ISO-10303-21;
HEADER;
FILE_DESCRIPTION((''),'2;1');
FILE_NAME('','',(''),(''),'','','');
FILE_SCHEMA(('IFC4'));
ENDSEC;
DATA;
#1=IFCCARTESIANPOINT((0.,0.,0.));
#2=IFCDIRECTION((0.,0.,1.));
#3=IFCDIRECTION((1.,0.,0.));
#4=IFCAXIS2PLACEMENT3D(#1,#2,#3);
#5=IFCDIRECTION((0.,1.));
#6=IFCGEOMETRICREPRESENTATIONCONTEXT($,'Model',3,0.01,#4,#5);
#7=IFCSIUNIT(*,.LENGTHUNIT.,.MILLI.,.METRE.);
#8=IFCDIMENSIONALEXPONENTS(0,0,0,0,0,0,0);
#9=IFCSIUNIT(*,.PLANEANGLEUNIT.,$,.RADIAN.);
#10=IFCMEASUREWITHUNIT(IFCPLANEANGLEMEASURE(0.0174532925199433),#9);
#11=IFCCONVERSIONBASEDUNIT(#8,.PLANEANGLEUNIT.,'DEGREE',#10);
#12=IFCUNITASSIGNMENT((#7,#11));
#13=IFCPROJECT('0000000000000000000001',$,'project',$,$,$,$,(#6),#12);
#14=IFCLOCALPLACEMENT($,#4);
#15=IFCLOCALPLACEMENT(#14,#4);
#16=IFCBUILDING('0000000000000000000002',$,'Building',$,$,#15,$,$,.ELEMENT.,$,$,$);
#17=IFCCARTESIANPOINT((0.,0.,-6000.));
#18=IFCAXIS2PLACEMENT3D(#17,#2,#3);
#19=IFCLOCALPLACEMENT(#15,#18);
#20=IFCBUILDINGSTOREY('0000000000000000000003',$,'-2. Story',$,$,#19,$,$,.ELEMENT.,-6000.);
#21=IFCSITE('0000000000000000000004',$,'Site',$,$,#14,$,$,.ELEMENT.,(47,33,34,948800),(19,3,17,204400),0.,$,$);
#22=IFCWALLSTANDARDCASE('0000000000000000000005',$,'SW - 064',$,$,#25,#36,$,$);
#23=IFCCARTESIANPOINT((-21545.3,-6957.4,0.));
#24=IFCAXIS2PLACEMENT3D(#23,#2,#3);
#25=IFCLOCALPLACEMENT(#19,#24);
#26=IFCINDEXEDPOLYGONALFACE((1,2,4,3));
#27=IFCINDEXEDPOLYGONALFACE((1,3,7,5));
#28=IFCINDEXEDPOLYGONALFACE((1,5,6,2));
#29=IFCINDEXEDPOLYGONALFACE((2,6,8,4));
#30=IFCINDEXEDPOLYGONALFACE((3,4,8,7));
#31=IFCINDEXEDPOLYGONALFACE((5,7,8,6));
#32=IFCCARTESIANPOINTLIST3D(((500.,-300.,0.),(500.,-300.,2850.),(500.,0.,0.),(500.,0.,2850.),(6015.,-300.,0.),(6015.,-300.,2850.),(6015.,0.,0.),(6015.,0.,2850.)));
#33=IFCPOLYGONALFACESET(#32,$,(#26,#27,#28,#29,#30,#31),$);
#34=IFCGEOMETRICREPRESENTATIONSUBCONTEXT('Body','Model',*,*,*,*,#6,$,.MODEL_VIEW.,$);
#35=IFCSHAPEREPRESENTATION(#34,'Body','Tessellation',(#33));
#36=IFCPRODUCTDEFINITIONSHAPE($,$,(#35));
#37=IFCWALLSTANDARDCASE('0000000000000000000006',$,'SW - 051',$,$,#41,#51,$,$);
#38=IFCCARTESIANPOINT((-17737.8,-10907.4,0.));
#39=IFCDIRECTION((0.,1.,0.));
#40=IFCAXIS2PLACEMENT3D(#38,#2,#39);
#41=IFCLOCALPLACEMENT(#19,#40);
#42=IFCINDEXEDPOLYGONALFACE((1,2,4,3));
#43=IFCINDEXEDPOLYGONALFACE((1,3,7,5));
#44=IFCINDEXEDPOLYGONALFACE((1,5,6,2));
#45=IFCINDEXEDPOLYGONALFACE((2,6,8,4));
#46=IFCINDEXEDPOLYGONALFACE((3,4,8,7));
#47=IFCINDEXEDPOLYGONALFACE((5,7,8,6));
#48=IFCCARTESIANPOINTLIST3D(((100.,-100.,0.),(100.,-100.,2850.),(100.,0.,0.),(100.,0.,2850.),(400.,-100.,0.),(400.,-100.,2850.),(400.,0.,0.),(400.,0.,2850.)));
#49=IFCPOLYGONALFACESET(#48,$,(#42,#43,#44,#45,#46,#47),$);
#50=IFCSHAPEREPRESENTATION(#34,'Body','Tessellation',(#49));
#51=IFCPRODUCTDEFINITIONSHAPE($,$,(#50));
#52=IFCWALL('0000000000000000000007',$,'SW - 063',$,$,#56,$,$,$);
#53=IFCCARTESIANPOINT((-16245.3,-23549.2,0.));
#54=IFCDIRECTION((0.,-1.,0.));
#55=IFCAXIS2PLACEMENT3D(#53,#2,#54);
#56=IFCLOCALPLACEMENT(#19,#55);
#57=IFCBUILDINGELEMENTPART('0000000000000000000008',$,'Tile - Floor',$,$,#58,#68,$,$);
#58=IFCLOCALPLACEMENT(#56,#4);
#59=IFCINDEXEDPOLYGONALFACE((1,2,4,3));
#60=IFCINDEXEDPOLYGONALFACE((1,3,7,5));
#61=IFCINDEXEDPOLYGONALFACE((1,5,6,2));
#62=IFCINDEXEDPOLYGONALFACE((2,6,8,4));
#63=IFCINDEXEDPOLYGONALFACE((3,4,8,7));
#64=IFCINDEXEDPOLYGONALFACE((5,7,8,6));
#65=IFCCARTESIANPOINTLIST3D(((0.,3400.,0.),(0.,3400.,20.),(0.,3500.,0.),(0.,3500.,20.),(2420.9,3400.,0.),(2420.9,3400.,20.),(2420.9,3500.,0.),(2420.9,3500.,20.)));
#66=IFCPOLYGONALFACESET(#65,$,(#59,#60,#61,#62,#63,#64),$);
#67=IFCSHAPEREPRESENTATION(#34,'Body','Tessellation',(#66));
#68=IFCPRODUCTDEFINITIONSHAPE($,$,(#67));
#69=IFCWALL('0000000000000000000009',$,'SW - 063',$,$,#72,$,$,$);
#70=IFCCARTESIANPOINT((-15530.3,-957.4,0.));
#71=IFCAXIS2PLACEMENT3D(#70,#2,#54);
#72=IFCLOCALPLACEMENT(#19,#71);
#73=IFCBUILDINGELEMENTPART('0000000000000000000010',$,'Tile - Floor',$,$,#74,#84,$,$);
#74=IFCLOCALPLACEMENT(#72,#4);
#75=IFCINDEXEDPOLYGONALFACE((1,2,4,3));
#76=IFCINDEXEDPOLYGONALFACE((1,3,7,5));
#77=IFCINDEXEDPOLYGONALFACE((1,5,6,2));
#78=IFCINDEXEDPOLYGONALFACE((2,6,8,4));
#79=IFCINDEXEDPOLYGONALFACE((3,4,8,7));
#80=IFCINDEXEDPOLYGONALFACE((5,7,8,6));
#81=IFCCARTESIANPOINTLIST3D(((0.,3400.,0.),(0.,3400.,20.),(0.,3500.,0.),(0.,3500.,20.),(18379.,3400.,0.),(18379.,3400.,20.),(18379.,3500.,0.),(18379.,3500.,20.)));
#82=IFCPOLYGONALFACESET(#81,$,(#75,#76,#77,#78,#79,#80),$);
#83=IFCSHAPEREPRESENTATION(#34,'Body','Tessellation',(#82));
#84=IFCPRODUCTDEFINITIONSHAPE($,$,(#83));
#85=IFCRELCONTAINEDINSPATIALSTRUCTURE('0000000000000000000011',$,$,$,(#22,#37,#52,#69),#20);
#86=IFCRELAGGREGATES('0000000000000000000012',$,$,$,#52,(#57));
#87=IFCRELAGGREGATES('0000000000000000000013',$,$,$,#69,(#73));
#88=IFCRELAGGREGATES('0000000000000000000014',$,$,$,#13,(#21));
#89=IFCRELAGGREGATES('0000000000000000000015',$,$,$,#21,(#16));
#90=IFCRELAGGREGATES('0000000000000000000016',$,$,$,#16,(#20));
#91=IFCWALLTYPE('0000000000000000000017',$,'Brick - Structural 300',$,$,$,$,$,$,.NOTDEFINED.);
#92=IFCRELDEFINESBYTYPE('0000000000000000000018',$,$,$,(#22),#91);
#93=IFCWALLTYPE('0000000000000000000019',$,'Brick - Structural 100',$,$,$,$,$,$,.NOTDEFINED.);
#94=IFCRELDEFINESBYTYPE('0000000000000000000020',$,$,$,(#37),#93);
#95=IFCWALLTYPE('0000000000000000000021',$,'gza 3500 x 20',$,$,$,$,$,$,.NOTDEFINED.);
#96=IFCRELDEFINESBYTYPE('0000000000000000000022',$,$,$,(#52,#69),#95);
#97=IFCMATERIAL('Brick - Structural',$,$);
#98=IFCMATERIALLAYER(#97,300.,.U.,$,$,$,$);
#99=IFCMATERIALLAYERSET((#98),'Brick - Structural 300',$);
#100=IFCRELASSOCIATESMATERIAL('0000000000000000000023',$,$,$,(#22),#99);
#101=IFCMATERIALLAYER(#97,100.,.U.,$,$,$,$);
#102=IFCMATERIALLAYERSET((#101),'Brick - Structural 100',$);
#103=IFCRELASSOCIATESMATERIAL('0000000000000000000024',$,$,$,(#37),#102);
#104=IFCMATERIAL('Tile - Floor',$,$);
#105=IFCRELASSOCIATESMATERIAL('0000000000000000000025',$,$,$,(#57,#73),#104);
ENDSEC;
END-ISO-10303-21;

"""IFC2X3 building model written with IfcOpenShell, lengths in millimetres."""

from ifc_helpers import new_model, entity, si_unit, converted_unit, direction, frame, origin_with_axes, place, context, subcontext, project, spatial, polyline, outline, extrude, material, layer, layer_set, layer_usage, type_object, element, aggregate, save


model = new_model("IFC2X3")

# Units and contexts
model_context = context("Model", 3, precision=0.01, world=origin_with_axes(), true_north=direction((0.0, 1.0)))
body_context = subcontext(model_context, "Body", "Model", "MODEL_VIEW")
ifc_project = project(units=[si_unit("LENGTHUNIT", "METRE", prefix="MILLI"), converted_unit("PLANEANGLEUNIT", "DEGREE", entity("IfcPlaneAngleMeasure", 0.0174532925199433), si_unit("PLANEANGLEUNIT", "RADIAN"), dimensions=[0, 0, 0, 0, 0, 0, 0])], contexts=[model_context])

# Site, building, storey
site_placement = place(None, origin_with_axes())
site = spatial("IfcSite", under=ifc_project, at=site_placement, Name="Site", CompositionType="ELEMENT", RefLatitude=(47, 33, 34, 948800), RefLongitude=(19, 3, 17, 204400), RefElevation=0.0)
building_placement = place(site_placement, origin_with_axes())
building = spatial("IfcBuilding", under=site, at=building_placement, Name="Building", CompositionType="ELEMENT")
storey_placement = place(building_placement, frame((0.0, 0.0, -6000.0), z_axis=(0.0, 0.0, 1.0), x_axis=(1.0, 0.0, 0.0)))
storey = spatial("IfcBuildingStorey", under=building, at=storey_placement, Name="-2. Story", CompositionType="ELEMENT", Elevation=-6000.0)

# Wall
ifc_material_1 = material(Name="Brick - Structural")
ifc_layer_1 = layer(ifc_material_1, 300.0, ventilated="UNKNOWN")
ifc_layer_set_1 = layer_set([ifc_layer_1], Name="Brick - Structural 300")
wall_type_1 = type_object("IfcWallType", Name="Brick - Structural 300", PredefinedType="NOTDEFINED")
ifc_layer_usage_1 = layer_usage(ifc_layer_set_1, "AXIS2", "NEGATIVE", 0.0)
wall_1_placement = place(storey_placement, frame((-21545.3, -6957.4, 0.0), z_axis=(0.0, 0.0, 1.0), x_axis=(1.0, 0.0, 0.0)))
element("IfcWallStandardCase", 1, at=wall_1_placement, inside=storey, type_object=wall_type_1, material=ifc_layer_usage_1, Name="SW - 064", context=body_context, shape_type="SweptSolid", body=[
    extrude(outline(polyline([(500.0, -300.0), (6015.0, -300.0), (6015.0, 0.0), (500.0, 0.0), (500.0, -300.0)])), origin_with_axes(), (0.0, 0.0, 1.0), 2850.0),
])

# Wall
ifc_layer_2 = layer(ifc_material_1, 100.0, ventilated="UNKNOWN")
ifc_layer_set_2 = layer_set([ifc_layer_2], Name="Brick - Structural 100")
wall_type_2 = type_object("IfcWallType", Name="Brick - Structural 100", PredefinedType="NOTDEFINED")
ifc_layer_usage_2 = layer_usage(ifc_layer_set_2, "AXIS2", "NEGATIVE", 0.0)
wall_2_placement = place(storey_placement, frame((-17737.8, -10907.4, 0.0), z_axis=(0.0, 0.0, 1.0), x_axis=(0.0, 1.0, 0.0)))
element("IfcWallStandardCase", 2, at=wall_2_placement, inside=storey, type_object=wall_type_2, material=ifc_layer_usage_2, Name="SW - 051", context=body_context, shape_type="SweptSolid", body=[
    extrude(outline(polyline([(100.0, -100.0), (400.0, -100.0), (400.0, 0.0), (100.0, 0.0), (100.0, -100.0)])), origin_with_axes(), (0.0, 0.0, 1.0), 2850.0),
])

# Walls, building element parts
wall_type_3 = type_object("IfcWallType", Name="gza 3500 x 20", PredefinedType="NOTDEFINED")
ifc_material_2 = material(Name="Tile - Floor")
wall_3_placement = place(storey_placement, frame((-16245.3, -23549.2, 0.0), z_axis=(0.0, 0.0, 1.0), x_axis=(0.0, -1.0, 0.0)))
wall_3 = element("IfcWall", 3, at=wall_3_placement, inside=storey, type_object=wall_type_3, Name="SW - 063")
building_element_part_1_placement = place(wall_3_placement, origin_with_axes())
building_element_part_1 = element("IfcBuildingElementPart", 4, at=building_element_part_1_placement, material=ifc_material_2, Name="Tile - Floor", context=body_context, shape_type="SweptSolid", body=[
    extrude(outline(polyline([(3400.0, 20.0), (3400.0, 0.0), (3500.0, 0.0), (3500.0, 20.0), (3400.0, 20.0)])), frame((0.0, 0.0, 0.0), z_axis=(1.0, 0.0, 0.0), x_axis=(0.0, 1.0, 0.0)), (0.0, 0.0, 1.0), 2420.9),
])
aggregate(wall_3, [building_element_part_1])
wall_4_placement = place(storey_placement, frame((-15530.3, -957.4, 0.0), z_axis=(0.0, 0.0, 1.0), x_axis=(0.0, -1.0, 0.0)))
wall_4 = element("IfcWall", 5, at=wall_4_placement, inside=storey, type_object=wall_type_3, Name="SW - 063")
building_element_part_2_placement = place(wall_4_placement, origin_with_axes())
building_element_part_2 = element("IfcBuildingElementPart", 6, at=building_element_part_2_placement, material=ifc_material_2, Name="Tile - Floor", context=body_context, shape_type="SweptSolid", body=[
    extrude(outline(polyline([(3400.0, 20.0), (3400.0, 0.0), (3500.0, 0.0), (3500.0, 20.0), (3400.0, 20.0)])), frame((0.0, 0.0, 0.0), z_axis=(1.0, 0.0, 0.0), x_axis=(0.0, 1.0, 0.0)), (0.0, 0.0, 1.0), 18379.0),
])
aggregate(wall_4, [building_element_part_2])

save(model, "model.ifc")
